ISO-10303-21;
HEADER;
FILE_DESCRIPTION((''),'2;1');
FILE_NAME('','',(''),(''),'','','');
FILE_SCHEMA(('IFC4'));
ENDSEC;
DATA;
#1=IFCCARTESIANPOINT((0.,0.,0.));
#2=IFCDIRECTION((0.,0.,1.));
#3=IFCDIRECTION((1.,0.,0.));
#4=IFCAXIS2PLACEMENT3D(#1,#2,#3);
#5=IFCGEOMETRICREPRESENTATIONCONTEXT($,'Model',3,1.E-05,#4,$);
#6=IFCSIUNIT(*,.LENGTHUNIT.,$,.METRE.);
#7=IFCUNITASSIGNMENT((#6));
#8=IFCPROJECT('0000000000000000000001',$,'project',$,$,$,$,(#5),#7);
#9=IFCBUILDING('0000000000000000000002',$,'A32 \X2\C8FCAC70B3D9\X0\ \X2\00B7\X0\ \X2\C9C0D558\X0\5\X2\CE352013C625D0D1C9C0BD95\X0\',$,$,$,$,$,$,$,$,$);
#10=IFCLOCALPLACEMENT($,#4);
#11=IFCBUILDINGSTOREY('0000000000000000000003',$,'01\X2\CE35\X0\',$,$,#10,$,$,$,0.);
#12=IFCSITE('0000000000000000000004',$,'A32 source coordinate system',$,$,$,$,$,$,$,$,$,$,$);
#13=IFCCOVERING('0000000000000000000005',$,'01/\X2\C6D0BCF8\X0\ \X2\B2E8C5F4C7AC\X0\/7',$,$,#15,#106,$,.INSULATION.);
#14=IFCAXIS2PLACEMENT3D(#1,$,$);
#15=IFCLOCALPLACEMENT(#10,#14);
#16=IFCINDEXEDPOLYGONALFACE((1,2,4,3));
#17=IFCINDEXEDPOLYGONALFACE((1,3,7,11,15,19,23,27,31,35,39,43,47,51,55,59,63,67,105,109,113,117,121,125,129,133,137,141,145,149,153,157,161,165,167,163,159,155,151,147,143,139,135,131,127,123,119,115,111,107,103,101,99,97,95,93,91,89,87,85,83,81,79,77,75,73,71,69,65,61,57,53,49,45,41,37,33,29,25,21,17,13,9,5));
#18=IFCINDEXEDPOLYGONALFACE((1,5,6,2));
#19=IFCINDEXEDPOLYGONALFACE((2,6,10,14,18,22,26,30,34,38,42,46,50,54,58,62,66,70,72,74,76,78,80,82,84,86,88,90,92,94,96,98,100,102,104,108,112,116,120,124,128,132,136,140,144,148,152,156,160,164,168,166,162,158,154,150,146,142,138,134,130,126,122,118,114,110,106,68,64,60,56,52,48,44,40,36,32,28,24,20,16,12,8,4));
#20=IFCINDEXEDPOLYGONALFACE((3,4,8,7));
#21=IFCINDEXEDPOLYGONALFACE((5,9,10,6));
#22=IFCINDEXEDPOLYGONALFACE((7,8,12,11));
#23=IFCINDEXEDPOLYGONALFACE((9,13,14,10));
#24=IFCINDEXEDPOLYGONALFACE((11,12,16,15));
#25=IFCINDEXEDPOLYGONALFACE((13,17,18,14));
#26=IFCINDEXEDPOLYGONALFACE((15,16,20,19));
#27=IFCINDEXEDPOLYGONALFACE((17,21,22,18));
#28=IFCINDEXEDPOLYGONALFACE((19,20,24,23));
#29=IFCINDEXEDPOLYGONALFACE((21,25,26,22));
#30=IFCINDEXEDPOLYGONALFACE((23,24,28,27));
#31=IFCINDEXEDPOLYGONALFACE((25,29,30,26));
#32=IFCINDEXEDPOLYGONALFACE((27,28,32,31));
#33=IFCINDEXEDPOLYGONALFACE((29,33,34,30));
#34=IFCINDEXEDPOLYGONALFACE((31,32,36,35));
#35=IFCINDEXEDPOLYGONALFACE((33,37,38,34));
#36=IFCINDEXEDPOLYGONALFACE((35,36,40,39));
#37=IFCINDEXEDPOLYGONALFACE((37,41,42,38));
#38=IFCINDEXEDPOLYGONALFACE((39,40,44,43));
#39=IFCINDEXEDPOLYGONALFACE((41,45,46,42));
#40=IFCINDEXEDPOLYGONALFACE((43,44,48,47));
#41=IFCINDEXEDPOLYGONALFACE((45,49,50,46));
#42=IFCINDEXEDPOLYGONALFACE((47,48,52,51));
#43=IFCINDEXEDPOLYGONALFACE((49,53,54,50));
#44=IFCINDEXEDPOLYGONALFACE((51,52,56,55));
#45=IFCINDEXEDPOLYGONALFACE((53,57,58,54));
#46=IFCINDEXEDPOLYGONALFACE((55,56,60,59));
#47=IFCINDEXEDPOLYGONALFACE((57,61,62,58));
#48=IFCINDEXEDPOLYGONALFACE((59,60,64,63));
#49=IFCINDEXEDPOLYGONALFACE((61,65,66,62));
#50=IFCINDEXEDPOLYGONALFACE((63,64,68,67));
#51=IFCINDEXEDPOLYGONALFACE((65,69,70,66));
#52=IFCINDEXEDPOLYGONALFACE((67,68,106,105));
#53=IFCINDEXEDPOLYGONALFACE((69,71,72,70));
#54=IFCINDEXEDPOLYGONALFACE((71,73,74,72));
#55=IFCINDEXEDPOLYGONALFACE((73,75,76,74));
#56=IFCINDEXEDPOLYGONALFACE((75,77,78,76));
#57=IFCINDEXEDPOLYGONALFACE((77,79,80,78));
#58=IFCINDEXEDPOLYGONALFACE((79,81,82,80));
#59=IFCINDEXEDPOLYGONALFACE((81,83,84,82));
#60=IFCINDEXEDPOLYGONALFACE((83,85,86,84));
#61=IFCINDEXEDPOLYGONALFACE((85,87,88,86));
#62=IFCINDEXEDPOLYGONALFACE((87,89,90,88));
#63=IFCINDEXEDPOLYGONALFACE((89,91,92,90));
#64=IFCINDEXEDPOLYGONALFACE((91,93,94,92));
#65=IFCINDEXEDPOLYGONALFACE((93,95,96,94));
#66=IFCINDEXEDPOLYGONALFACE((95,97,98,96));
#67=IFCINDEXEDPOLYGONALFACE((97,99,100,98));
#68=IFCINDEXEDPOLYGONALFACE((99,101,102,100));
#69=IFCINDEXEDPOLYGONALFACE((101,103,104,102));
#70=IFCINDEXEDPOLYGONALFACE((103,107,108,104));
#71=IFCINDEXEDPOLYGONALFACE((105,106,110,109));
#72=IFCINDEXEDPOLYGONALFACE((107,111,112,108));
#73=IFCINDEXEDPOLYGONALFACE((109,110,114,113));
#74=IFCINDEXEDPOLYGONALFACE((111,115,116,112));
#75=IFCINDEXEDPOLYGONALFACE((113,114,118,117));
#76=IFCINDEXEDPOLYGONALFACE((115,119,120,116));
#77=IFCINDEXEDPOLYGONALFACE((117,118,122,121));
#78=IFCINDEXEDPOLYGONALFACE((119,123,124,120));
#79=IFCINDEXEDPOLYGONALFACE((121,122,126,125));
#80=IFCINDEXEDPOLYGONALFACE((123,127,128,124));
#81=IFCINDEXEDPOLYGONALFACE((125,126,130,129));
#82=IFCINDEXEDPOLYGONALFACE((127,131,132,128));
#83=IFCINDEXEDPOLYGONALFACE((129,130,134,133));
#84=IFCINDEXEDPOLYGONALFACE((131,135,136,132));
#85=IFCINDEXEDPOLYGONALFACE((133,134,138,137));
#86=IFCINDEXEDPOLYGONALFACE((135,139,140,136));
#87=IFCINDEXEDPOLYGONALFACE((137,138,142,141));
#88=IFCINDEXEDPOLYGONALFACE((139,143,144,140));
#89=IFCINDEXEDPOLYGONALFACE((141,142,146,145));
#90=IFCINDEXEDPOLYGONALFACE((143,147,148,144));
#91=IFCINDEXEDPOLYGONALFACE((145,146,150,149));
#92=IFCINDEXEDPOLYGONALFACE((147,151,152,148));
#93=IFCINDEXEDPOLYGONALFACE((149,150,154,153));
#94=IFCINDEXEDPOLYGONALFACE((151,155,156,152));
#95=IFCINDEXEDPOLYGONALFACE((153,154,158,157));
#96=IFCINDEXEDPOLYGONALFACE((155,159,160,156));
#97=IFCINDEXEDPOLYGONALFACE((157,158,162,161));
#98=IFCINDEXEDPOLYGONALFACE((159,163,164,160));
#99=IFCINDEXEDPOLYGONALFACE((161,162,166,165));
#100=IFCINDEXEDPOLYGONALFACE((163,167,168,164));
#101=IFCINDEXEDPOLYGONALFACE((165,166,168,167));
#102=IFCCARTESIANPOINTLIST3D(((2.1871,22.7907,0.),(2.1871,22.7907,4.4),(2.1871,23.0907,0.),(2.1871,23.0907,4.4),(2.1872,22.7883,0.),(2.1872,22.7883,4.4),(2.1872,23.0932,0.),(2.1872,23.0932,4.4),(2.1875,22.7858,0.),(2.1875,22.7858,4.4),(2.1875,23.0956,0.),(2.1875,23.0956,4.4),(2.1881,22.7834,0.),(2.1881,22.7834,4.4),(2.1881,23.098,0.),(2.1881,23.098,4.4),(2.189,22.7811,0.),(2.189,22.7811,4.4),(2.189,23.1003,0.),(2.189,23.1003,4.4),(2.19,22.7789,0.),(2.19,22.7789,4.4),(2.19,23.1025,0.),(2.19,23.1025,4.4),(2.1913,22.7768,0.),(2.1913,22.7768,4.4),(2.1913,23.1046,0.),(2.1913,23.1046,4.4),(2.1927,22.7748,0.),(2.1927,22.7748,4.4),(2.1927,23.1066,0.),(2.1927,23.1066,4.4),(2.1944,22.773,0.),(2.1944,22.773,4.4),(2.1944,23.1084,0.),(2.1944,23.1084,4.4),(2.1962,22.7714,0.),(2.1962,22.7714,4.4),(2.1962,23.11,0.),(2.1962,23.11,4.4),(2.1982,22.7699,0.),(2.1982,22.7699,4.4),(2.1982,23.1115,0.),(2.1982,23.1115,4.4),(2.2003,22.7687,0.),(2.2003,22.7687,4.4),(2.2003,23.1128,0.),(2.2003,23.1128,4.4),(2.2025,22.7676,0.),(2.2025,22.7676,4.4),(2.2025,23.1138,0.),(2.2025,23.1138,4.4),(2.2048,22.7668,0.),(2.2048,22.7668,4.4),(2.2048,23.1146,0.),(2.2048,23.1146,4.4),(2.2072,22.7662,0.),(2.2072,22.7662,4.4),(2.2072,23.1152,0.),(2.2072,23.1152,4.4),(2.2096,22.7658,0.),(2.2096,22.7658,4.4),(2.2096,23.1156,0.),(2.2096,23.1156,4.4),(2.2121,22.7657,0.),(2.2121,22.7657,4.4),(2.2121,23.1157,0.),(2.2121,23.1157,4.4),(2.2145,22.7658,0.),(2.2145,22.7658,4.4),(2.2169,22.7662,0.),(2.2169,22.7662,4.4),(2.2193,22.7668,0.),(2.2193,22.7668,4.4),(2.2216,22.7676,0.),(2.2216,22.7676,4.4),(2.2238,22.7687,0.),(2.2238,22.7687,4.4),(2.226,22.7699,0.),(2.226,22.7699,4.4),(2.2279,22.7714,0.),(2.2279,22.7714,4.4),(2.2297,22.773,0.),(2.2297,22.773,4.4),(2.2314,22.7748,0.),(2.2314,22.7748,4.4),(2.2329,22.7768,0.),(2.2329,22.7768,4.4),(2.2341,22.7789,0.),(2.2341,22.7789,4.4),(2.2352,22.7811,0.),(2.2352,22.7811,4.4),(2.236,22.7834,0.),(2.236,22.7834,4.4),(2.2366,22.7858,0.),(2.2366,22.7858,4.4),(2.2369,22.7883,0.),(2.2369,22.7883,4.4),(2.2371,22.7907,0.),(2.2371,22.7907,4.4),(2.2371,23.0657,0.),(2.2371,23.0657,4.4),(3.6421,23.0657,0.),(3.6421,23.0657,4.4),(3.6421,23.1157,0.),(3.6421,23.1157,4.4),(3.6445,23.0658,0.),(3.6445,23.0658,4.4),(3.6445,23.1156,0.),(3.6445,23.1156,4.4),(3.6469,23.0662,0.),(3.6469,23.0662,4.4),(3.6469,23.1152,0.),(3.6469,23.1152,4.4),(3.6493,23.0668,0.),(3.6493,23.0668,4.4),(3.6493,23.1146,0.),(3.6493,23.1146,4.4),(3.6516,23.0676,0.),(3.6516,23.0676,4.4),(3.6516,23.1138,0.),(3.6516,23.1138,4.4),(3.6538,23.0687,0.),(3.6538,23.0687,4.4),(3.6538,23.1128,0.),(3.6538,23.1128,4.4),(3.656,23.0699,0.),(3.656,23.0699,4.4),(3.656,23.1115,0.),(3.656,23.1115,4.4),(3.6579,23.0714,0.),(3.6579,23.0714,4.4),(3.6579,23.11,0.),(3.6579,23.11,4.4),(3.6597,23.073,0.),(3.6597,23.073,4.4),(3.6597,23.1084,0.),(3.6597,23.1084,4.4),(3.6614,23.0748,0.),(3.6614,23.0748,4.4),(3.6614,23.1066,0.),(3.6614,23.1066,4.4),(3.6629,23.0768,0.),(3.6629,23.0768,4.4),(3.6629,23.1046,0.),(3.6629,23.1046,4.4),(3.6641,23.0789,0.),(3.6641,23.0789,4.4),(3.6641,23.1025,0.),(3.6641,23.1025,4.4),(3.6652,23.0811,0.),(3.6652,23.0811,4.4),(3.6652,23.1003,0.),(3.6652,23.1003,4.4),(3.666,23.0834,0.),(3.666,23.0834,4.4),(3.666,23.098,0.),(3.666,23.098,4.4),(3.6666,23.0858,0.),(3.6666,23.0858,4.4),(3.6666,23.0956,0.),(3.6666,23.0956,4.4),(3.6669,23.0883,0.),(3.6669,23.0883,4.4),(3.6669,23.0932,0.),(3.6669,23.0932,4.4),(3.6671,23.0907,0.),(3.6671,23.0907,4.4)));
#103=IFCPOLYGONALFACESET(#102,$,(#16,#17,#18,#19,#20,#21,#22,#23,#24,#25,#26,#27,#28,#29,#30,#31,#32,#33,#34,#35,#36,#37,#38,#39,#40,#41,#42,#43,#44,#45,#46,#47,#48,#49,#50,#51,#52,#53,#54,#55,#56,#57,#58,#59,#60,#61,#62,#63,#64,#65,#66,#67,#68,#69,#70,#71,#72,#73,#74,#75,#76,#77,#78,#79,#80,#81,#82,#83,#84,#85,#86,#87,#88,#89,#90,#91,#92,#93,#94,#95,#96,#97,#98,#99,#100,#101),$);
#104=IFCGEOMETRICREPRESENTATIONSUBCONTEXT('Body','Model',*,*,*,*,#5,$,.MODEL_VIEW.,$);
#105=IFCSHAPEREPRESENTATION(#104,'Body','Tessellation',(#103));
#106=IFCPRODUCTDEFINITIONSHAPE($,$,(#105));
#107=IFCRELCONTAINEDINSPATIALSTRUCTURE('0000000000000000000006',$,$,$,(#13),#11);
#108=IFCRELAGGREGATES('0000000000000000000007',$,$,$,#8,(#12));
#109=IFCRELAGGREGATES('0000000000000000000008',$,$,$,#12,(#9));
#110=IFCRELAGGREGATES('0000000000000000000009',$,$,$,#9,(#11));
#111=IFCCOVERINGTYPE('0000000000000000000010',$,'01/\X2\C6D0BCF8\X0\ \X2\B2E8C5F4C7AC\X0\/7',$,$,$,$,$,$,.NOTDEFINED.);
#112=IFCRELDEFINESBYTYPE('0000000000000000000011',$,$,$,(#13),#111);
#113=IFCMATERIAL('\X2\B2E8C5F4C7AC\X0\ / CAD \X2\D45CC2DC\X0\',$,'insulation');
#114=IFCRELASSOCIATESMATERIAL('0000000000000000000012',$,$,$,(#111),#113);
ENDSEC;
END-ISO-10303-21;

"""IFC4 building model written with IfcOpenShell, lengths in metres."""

from ifc_helpers import new_model, si_unit, origin, origin_with_axes, place, context, subcontext, project, spatial, polyline, outline, extrude, source, transform, mapped, material, type_object, type_shapes, element, save


model = new_model("IFC4")

# Units and contexts
model_context = context("Model", 3, precision=1e-05, world=origin_with_axes())
body_context = subcontext(model_context, "Body", "Model", "MODEL_VIEW")
ifc_project = project(units=[si_unit("LENGTHUNIT", "METRE")], contexts=[model_context])

# Site, building, storey
site = spatial("IfcSite", under=ifc_project, Name="A32 source coordinate system")
building = spatial("IfcBuilding", under=site, Name="A32 주거동 · 지하5층–옥탑지붕")
storey_placement = place(None, origin_with_axes())
storey = spatial("IfcBuildingStorey", under=building, at=storey_placement, Name="01층", Elevation=0.0)

# Covering
ifc_material = material(Name="단열재 / CAD 표시", Category="insulation")
covering_type_1 = type_object("IfcCoveringType", Name="01/원본 단열재/7", PredefinedType="NOTDEFINED", material=ifc_material)
shared_shape_1 = source(origin(), body_context, "Body", "SweptSolid", [
    extrude(outline(polyline([(2.19, 23.1025), (2.1913, 23.1046), (2.1927, 23.1066), (2.1944, 23.1084), (2.1962, 23.11), (2.1982, 23.1115), (2.2003, 23.1128), (2.2025, 23.1138), (2.2048, 23.1146), (2.2072, 23.1152), (2.2096, 23.1156), (2.2121, 23.1157), (3.6421, 23.1157), (3.6445, 23.1156), (3.6469, 23.1152), (3.6493, 23.1146), (3.6516, 23.1138), (3.6538, 23.1128), (3.656, 23.1115), (3.6579, 23.11), (3.6597, 23.1084), (3.6614, 23.1066), (3.6629, 23.1046), (3.6641, 23.1025), (3.6652, 23.1003), (3.666, 23.098), (3.6666, 23.0956), (3.6669, 23.0932), (3.6671, 23.0907), (3.6669, 23.0883), (3.6666, 23.0858), (3.666, 23.0834), (3.6652, 23.0811), (3.6641, 23.0789), (3.6629, 23.0768), (3.6614, 23.0748), (3.6597, 23.073), (3.6579, 23.0714), (3.656, 23.0699), (3.6538, 23.0687), (3.6516, 23.0676), (3.6493, 23.0668), (3.6469, 23.0662), (3.6445, 23.0658), (3.6421, 23.0657), (2.2371, 23.0657), (2.2371, 22.7907), (2.2369, 22.7883), (2.2366, 22.7858), (2.236, 22.7834), (2.2352, 22.7811), (2.2341, 22.7789), (2.2329, 22.7768), (2.2314, 22.7748), (2.2297, 22.773), (2.2279, 22.7714), (2.226, 22.7699), (2.2238, 22.7687), (2.2216, 22.7676), (2.2193, 22.7668), (2.2169, 22.7662), (2.2145, 22.7658), (2.2121, 22.7657), (2.2096, 22.7658), (2.2072, 22.7662), (2.2048, 22.7668), (2.2025, 22.7676), (2.2003, 22.7687), (2.1982, 22.7699), (2.1962, 22.7714), (2.1944, 22.773), (2.1927, 22.7748), (2.1913, 22.7768), (2.19, 22.7789), (2.189, 22.7811), (2.1881, 22.7834), (2.1875, 22.7858), (2.1872, 22.7883), (2.1871, 22.7907), (2.1871, 23.0907), (2.1872, 23.0932), (2.1875, 23.0956), (2.1881, 23.098), (2.189, 23.1003), (2.19, 23.1025)])), origin(), (0.0, 0.0, 1.0), 4.4),
])
type_shapes(covering_type_1, [shared_shape_1])
covering_1_placement = place(storey_placement, origin_with_axes())
element("IfcCovering", 1, at=covering_1_placement, inside=storey, type_object=covering_type_1, Name="01/원본 단열재/7", PredefinedType="INSULATION", context=body_context, shape_type="MappedRepresentation", body=[
    mapped(shared_shape_1, transform((0.0, 0.0, 0.0), scale=1.0)),
])

save(model, "model.ifc")
